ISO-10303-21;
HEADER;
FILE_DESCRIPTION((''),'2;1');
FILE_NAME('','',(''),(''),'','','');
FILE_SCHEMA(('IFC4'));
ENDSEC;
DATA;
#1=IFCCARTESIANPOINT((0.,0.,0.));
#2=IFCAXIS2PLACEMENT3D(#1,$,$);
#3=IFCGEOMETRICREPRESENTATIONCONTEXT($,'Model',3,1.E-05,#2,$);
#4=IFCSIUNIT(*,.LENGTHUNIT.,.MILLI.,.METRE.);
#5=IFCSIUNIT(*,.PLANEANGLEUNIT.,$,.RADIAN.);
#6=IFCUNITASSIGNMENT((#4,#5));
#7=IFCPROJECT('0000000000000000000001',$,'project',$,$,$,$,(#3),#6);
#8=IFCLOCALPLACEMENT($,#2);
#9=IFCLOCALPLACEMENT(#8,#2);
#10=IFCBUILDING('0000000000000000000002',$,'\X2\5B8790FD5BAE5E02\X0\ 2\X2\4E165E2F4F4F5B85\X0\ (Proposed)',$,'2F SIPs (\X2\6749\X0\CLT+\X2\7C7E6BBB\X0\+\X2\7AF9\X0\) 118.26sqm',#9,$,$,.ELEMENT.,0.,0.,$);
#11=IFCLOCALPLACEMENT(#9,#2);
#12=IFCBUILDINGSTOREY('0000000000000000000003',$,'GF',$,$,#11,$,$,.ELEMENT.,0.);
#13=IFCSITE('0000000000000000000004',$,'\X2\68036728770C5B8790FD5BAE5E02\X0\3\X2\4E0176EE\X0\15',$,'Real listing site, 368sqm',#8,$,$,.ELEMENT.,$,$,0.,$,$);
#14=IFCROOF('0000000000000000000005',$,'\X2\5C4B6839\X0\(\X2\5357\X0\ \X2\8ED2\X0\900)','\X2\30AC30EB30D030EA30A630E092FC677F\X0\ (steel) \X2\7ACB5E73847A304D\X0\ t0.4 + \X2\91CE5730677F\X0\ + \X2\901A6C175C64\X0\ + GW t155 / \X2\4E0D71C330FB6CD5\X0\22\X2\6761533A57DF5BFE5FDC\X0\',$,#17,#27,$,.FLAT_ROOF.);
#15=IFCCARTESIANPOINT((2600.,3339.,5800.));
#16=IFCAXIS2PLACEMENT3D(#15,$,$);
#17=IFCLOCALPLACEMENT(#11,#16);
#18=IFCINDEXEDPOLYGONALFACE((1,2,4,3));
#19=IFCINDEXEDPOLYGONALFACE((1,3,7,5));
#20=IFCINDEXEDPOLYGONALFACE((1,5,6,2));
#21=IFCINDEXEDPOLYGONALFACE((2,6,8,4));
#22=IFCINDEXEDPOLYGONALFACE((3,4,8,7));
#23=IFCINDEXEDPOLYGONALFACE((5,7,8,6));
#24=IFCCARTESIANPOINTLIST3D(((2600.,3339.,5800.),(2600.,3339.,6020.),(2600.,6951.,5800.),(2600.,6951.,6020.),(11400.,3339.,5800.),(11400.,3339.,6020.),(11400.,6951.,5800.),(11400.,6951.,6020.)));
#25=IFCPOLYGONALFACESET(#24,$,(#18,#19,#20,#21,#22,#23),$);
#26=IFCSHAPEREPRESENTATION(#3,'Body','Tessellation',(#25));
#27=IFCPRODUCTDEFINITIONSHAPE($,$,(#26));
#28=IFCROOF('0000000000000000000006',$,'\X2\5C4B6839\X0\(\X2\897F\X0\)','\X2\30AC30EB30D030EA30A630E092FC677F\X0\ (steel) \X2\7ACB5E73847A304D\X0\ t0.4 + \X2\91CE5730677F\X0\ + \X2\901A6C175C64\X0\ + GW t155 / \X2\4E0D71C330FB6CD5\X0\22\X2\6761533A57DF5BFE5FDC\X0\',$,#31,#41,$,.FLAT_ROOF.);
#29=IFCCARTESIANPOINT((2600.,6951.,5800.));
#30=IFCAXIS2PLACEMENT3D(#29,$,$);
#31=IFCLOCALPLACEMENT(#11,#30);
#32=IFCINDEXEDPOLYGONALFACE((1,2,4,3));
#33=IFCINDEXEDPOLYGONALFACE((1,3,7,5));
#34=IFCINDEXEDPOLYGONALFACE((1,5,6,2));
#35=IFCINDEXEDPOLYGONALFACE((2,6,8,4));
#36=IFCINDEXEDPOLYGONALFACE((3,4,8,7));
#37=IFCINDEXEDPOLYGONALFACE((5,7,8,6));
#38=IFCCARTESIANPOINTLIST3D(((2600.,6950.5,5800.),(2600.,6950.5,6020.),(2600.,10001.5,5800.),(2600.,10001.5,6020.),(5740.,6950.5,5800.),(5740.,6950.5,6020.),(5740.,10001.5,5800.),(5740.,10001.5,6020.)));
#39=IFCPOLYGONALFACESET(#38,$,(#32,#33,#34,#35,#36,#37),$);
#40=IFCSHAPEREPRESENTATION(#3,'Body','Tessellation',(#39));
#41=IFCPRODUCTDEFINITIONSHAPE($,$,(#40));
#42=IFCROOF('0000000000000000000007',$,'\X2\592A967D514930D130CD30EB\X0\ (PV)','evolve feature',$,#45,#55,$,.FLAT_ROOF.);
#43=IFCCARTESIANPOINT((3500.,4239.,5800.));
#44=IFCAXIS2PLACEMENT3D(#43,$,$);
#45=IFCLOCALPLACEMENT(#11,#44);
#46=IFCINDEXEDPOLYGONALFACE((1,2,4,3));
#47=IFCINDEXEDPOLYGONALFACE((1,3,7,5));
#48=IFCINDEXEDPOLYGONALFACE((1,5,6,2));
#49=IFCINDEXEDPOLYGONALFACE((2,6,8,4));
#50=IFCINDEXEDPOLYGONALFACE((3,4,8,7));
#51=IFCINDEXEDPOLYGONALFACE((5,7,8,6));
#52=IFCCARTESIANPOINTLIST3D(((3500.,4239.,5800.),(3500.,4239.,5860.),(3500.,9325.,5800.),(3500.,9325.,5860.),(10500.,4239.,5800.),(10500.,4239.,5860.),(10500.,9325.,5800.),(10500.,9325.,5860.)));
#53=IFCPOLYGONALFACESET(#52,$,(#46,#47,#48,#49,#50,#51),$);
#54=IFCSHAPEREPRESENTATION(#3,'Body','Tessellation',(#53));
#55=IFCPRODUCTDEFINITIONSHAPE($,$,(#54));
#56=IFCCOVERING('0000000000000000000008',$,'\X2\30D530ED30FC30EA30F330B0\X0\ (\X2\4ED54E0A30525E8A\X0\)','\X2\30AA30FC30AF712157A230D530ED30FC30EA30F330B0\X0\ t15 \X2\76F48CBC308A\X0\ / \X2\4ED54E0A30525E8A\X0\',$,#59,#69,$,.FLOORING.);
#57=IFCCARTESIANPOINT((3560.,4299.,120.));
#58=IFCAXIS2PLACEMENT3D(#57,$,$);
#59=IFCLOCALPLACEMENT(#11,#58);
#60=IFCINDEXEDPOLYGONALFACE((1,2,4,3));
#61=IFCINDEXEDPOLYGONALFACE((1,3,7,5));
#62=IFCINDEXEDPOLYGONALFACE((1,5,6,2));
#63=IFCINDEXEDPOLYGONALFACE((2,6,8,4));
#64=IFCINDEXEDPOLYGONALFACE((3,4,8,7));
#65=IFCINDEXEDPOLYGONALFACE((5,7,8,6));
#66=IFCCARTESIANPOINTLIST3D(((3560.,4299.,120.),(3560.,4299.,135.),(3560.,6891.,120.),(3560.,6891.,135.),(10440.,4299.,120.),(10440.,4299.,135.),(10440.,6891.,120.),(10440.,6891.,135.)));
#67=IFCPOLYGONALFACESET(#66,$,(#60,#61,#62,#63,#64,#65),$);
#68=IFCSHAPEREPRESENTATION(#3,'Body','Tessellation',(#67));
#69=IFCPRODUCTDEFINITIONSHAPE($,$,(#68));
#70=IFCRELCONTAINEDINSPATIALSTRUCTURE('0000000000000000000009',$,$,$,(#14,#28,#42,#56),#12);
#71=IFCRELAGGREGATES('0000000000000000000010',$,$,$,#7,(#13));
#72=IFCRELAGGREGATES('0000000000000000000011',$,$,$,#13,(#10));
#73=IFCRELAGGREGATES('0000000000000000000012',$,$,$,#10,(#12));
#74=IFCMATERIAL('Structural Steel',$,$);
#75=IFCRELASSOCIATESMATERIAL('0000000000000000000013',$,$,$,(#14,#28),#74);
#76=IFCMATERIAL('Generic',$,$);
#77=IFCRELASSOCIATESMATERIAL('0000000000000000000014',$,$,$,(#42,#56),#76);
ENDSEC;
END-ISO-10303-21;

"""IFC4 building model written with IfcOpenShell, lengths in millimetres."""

from ifc_helpers import new_model, si_unit, frame, frame_2d, origin, place, context, project, spatial, rectangle, extrude, material, element, save


model = new_model("IFC4")

# Units and contexts
model_context = context("Model", 3, precision=1e-05, world=origin())
ifc_project = project(units=[si_unit("LENGTHUNIT", "METRE", prefix="MILLI"), si_unit("PLANEANGLEUNIT", "RADIAN")], contexts=[model_context])

# Site, building, storey
site_placement = place(None, origin())
site = spatial("IfcSite", under=ifc_project, at=site_placement, Name="栃木県宇都宮市3丁目15", ObjectType="Real listing site, 368sqm", CompositionType="ELEMENT", RefElevation=0.0)
building_placement = place(site_placement, origin())
building = spatial("IfcBuilding", under=site, at=building_placement, Name="宇都宮市 2世帯住宅 (Proposed)", ObjectType="2F SIPs (杉CLT+籾殻+竹) 118.26sqm", CompositionType="ELEMENT", ElevationOfRefHeight=0.0, ElevationOfTerrain=0.0)
storey_placement = place(building_placement, origin())
storey = spatial("IfcBuildingStorey", under=building, at=storey_placement, Name="GF", CompositionType="ELEMENT", Elevation=0.0)

# Shared definitions
ifc_material_1 = material(Name="Generic")

# Roofs
ifc_material_2 = material(Name="Structural Steel")
roof_1_placement = place(storey_placement, frame((2600.0, 3339.0, 5800.0)))
element("IfcRoof", 1, at=roof_1_placement, inside=storey, material=ifc_material_2, Name="屋根(南 軒900)", Description="ガルバリウム鋼板 (steel) 立平葺き t0.4 + 野地板 + 通気層 + GW t155 / 不燃・法22条区域対応", PredefinedType="FLAT_ROOF", context=model_context, shape_type="SweptSolid", body=[
    extrude(rectangle(XDim=8800.0, YDim=3612.0, at=frame_2d((4400.0, 1806.0))), frame((2600.0, 3339.0, 5800.0)), (0.0, 0.0, 1.0), 220.0),
])
roof_2_placement = place(storey_placement, frame((2600.0, 6951.0, 5800.0)))
element("IfcRoof", 2, at=roof_2_placement, inside=storey, material=ifc_material_2, Name="屋根(西)", Description="ガルバリウム鋼板 (steel) 立平葺き t0.4 + 野地板 + 通気層 + GW t155 / 不燃・法22条区域対応", PredefinedType="FLAT_ROOF", context=model_context, shape_type="SweptSolid", body=[
    extrude(rectangle(XDim=3140.0, YDim=3051.0, at=frame_2d((1570.0, 1525.0))), frame((2600.0, 6951.0, 5800.0)), (0.0, 0.0, 1.0), 220.0),
])
roof_3_placement = place(storey_placement, frame((3500.0, 4239.0, 5800.0)))
element("IfcRoof", 3, at=roof_3_placement, inside=storey, material=ifc_material_1, Name="太陽光パネル (PV)", Description="evolve feature", PredefinedType="FLAT_ROOF", context=model_context, shape_type="SweptSolid", body=[
    extrude(rectangle(XDim=7000.0, YDim=5086.0, at=frame_2d((3500.0, 2543.0))), frame((3500.0, 4239.0, 5800.0)), (0.0, 0.0, 1.0), 60.0),
])

# Covering
covering_placement = place(storey_placement, frame((3560.0, 4299.0, 120.0)))
element("IfcCovering", 4, at=covering_placement, inside=storey, material=ifc_material_1, Name="フローリング (仕上げ床)", Description="オーク無垢フローリング t15 直貼り / 仕上げ床", PredefinedType="FLOORING", context=model_context, shape_type="SweptSolid", body=[
    extrude(rectangle(XDim=6880.0, YDim=2592.0, at=frame_2d((3440.0, 1296.0))), frame((3560.0, 4299.0, 120.0)), (0.0, 0.0, 1.0), 15.0),
])

save(model, "model.ifc")
